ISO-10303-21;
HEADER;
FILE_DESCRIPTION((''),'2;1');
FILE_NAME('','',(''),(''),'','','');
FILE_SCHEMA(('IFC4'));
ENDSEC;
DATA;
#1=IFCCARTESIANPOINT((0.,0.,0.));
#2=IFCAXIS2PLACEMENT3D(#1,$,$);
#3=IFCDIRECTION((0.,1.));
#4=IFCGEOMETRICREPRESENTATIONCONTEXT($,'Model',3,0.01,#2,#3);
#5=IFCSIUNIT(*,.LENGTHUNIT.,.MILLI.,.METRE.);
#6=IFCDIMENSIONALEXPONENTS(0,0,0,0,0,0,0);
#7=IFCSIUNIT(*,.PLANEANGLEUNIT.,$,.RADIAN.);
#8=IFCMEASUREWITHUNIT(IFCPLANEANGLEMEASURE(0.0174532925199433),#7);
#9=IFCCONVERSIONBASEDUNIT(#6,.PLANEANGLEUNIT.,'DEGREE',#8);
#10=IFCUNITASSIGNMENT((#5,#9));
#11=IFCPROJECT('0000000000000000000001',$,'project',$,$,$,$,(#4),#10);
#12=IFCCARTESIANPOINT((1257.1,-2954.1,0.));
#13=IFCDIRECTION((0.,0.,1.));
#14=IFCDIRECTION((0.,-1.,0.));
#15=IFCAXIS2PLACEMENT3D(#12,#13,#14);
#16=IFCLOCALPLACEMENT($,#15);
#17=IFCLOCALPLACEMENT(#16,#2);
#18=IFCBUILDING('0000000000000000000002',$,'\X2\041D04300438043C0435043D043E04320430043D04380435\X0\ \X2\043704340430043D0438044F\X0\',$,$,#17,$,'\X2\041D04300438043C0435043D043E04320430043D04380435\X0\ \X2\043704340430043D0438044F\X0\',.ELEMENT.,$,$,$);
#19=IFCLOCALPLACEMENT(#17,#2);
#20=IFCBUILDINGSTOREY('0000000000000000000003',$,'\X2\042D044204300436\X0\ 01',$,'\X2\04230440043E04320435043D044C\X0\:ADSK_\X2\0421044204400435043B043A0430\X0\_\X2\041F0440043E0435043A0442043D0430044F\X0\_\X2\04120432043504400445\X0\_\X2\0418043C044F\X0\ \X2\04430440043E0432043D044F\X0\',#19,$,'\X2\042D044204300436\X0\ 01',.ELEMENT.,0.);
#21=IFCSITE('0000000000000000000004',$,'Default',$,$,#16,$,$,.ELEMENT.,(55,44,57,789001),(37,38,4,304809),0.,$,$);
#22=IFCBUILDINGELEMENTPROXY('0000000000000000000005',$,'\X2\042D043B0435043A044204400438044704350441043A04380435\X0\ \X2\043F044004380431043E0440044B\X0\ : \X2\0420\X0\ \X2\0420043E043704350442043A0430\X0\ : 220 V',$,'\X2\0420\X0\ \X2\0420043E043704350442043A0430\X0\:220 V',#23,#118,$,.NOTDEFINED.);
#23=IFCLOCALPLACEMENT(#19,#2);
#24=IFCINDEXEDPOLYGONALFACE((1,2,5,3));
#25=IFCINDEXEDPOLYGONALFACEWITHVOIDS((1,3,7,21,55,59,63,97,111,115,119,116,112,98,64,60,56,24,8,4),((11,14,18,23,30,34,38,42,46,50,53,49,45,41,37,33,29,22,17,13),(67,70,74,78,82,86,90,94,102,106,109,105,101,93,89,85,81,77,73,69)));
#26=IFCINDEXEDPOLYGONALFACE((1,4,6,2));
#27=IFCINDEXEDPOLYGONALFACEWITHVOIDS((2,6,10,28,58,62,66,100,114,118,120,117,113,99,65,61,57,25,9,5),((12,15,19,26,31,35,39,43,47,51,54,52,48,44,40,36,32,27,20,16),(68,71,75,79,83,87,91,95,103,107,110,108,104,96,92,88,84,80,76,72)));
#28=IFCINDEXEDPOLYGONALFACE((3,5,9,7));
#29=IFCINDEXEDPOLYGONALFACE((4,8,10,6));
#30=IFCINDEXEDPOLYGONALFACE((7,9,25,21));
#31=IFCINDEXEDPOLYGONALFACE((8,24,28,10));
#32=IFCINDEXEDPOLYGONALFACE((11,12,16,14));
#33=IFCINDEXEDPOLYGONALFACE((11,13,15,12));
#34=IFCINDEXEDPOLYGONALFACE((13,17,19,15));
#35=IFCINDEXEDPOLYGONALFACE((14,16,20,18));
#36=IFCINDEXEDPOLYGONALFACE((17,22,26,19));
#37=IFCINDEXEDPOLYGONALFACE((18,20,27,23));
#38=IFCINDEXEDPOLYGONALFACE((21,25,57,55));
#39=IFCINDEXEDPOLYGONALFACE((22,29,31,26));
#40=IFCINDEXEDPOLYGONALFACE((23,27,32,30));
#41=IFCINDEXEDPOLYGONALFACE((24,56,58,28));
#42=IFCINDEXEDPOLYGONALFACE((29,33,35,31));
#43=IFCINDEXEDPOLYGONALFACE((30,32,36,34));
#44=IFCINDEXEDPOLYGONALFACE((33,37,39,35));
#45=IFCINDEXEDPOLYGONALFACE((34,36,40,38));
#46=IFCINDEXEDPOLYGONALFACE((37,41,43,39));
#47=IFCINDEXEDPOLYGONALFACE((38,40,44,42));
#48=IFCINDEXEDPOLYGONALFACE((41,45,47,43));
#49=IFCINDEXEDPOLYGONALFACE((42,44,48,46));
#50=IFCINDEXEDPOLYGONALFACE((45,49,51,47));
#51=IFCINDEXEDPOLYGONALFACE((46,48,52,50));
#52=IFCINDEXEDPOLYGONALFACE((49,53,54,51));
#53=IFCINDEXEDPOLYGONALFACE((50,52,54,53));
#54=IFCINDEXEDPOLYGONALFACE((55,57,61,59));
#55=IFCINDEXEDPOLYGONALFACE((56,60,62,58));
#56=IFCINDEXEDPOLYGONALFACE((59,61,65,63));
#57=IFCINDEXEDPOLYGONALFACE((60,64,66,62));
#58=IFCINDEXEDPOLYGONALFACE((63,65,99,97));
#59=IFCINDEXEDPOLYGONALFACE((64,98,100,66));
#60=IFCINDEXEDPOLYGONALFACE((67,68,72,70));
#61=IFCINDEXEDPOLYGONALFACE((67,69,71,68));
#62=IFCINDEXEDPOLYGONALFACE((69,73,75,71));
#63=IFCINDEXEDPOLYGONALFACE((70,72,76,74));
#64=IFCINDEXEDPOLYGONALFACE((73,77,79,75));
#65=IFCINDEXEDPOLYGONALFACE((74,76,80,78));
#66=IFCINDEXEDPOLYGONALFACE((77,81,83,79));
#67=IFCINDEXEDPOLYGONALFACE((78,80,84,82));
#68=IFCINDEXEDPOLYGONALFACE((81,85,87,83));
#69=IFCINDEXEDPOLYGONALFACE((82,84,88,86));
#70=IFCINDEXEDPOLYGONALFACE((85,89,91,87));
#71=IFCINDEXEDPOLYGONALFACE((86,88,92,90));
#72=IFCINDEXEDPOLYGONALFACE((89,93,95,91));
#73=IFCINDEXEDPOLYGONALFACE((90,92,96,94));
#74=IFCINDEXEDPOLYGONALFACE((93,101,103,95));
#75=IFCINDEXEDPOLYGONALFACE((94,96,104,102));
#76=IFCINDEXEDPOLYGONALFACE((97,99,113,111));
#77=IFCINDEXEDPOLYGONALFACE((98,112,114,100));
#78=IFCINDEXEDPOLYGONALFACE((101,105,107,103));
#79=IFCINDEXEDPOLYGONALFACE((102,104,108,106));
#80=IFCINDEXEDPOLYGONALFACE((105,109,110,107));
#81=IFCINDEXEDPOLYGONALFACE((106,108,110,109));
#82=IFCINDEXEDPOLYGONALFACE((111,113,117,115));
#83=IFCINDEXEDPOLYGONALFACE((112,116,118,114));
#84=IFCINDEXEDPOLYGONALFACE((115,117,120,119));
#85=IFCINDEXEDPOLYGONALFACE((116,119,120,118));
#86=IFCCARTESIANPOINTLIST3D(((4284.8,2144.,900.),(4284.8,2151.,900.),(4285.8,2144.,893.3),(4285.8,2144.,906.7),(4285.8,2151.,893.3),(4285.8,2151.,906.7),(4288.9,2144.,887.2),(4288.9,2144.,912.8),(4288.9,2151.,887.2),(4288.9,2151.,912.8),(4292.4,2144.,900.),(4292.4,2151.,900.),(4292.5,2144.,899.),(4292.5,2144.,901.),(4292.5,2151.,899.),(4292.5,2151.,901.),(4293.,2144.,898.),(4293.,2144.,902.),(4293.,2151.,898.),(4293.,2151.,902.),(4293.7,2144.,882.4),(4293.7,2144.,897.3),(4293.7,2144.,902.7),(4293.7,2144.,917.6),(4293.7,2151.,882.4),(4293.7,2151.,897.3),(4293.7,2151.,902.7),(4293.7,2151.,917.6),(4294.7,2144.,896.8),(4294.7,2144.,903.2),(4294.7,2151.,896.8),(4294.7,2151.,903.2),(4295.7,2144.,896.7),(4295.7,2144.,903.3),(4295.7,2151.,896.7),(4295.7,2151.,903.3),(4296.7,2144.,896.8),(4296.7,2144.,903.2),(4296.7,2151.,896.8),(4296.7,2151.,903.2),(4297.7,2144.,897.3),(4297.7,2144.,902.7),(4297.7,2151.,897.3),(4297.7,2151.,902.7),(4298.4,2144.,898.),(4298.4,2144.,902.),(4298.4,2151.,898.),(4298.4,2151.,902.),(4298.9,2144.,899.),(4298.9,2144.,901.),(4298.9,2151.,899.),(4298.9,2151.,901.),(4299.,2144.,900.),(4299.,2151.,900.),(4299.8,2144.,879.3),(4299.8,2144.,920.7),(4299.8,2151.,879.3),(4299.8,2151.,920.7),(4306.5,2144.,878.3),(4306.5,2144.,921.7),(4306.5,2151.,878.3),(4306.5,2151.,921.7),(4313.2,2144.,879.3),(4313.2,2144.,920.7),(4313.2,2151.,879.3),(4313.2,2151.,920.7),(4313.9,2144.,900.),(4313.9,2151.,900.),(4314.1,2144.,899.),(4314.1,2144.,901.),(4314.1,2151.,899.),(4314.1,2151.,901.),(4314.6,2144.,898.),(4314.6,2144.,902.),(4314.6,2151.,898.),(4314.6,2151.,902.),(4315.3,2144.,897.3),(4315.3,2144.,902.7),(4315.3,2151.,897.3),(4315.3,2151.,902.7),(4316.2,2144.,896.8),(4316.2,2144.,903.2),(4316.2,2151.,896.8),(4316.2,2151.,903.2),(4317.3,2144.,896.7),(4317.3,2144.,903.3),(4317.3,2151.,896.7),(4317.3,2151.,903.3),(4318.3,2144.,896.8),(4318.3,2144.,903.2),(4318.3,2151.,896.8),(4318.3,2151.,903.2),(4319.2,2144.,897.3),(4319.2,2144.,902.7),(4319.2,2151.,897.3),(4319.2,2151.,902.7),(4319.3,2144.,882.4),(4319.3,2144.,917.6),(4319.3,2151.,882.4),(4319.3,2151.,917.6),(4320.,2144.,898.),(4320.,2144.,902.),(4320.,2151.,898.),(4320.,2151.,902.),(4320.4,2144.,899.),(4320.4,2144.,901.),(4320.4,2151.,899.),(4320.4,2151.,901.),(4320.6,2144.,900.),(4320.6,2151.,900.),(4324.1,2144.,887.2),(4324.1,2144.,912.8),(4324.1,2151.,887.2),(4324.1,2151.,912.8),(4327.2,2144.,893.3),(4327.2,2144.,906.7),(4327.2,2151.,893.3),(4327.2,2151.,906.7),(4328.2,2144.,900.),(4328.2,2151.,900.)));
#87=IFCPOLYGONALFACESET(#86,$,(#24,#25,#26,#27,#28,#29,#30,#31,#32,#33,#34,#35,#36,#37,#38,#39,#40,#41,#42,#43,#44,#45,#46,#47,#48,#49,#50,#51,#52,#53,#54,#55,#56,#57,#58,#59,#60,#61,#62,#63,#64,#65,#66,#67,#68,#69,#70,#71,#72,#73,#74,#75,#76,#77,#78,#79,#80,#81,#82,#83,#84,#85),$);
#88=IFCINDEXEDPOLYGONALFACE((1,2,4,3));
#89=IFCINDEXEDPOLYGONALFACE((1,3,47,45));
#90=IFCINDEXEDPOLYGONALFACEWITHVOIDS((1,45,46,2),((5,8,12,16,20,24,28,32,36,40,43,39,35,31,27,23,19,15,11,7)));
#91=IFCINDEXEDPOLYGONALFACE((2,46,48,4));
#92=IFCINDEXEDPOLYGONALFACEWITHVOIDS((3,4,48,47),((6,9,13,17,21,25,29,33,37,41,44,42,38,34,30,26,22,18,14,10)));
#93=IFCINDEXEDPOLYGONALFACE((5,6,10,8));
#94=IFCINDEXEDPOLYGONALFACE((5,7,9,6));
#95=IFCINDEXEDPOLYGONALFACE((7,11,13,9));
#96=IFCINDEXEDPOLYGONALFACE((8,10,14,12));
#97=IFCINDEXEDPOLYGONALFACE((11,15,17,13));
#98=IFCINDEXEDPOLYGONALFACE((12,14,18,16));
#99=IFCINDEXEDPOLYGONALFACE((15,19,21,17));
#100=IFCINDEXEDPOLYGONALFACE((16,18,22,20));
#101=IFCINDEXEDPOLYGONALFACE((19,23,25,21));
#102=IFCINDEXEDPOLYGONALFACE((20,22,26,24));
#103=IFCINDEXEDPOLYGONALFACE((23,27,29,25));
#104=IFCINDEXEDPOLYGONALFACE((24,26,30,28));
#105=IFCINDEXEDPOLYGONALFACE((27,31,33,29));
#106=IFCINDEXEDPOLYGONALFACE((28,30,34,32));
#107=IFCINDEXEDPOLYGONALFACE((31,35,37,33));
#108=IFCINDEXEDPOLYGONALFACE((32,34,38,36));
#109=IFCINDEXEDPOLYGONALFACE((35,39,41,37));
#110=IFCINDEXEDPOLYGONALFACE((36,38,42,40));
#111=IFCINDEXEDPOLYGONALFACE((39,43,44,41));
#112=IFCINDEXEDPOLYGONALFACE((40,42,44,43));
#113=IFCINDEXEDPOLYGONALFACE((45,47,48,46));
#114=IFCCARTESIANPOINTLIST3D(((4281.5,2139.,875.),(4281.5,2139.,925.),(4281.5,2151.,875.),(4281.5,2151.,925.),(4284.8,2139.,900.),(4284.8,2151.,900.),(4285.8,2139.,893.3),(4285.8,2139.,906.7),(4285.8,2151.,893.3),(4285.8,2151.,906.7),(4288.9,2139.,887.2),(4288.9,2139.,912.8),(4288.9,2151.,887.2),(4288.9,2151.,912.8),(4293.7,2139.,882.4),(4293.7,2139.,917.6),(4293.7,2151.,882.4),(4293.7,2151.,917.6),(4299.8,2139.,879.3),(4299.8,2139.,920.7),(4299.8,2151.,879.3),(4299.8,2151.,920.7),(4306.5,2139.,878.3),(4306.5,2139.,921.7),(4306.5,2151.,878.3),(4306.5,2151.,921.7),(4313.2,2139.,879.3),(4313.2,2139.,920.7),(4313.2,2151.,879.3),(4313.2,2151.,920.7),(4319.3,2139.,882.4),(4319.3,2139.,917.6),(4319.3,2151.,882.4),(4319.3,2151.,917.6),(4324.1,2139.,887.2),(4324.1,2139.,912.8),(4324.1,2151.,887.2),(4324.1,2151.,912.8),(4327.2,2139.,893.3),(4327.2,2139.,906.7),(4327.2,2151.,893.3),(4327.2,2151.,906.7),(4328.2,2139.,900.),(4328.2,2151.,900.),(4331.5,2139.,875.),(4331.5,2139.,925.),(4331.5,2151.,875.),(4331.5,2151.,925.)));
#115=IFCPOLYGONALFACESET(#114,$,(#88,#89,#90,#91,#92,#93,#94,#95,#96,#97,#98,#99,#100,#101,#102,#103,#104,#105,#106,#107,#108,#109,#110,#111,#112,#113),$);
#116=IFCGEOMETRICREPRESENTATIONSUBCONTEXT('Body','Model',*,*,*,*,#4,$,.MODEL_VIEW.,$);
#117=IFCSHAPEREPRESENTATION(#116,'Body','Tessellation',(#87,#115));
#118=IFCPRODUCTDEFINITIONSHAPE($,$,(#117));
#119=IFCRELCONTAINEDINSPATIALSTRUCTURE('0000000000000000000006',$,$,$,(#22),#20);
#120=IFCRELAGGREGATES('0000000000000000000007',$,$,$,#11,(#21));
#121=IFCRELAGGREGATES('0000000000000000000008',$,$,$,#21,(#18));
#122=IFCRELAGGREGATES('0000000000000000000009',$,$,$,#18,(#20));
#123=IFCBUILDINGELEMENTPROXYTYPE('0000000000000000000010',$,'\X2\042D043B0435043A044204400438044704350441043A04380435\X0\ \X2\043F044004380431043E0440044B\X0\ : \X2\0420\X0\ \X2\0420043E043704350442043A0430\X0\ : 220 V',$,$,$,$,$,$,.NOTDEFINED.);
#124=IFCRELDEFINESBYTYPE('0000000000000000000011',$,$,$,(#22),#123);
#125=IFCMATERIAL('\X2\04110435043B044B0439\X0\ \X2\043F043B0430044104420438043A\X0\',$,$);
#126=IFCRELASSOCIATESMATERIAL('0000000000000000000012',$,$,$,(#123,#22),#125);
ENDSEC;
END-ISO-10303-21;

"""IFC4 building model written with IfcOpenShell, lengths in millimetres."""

from ifc_helpers import new_model, entity, si_unit, converted_unit, direction, frame, origin, place, context, subcontext, project, spatial, indexed_curve, outline, extrude, source, transform, mapped, material, type_object, type_shapes, element, save


model = new_model("IFC4")

# Units and contexts
model_context = context("Model", 3, precision=0.01, world=origin(), true_north=direction((0.0, 1.0)))
body_context = subcontext(model_context, "Body", "Model", "MODEL_VIEW")
ifc_project = project(units=[si_unit("LENGTHUNIT", "METRE", prefix="MILLI"), converted_unit("PLANEANGLEUNIT", "DEGREE", entity("IfcPlaneAngleMeasure", 0.0174532925199433), si_unit("PLANEANGLEUNIT", "RADIAN"), dimensions=[0, 0, 0, 0, 0, 0, 0])], contexts=[model_context])

# Site, building, storey
site_placement = place(None, frame((1257.1, -2954.1, 0.0), z_axis=(0.0, 0.0, 1.0), x_axis=(0.0, -1.0, 0.0)))
site = spatial("IfcSite", under=ifc_project, at=site_placement, Name="Default", CompositionType="ELEMENT", RefLatitude=(55, 44, 57, 789001), RefLongitude=(37, 38, 4, 304809), RefElevation=0.0)
building_placement = place(site_placement, origin())
building = spatial("IfcBuilding", under=site, at=building_placement, Name="Наименование здания", LongName="Наименование здания", CompositionType="ELEMENT")
storey_placement = place(building_placement, origin())
storey = spatial("IfcBuildingStorey", under=building, at=storey_placement, Name="Этаж 01", ObjectType="Уровень:ADSK_Стрелка_Проектная_Вверх_Имя уровня", LongName="Этаж 01", CompositionType="ELEMENT", Elevation=0.0)

# Building element proxy
ifc_material_1 = material(Name="Белый пластик")
building_element_proxy_type_1 = type_object("IfcBuildingElementProxyType", Name="Электрические приборы : Р Розетка : 220 V", PredefinedType="NOTDEFINED", material=ifc_material_1)
shared_shape_1 = source(origin(), body_context, "Body", "SweptSolid", [
    extrude(outline(indexed_curve([(21.7, 0.0), (20.7, 6.7), (17.6, 12.8), (12.8, 17.6), (6.7, 20.7), (0.0, 21.7), (-6.7, 20.7), (-12.8, 17.6), (-17.6, 12.8), (-20.7, 6.7), (-21.7, 0.0), (-20.7, -6.7), (-17.6, -12.8), (-12.8, -17.6), (-6.7, -20.7), (0.0, -21.7), (6.7, -20.7), (12.8, -17.6), (17.6, -12.8), (20.7, -6.7), (21.7, 0.0)], self_intersect=False), holes=[indexed_curve([(-7.5, 0.0), (-7.6, -1.0), (-8.1, -2.0), (-8.8, -2.7), (-9.8, -3.2), (-10.8, -3.3), (-11.8, -3.2), (-12.8, -2.7), (-13.5, -2.0), (-14.0, -1.0), (-14.1, 0.0), (-14.0, 1.0), (-13.5, 2.0), (-12.8, 2.7), (-11.8, 3.2), (-10.8, 3.3), (-9.8, 3.2), (-8.8, 2.7), (-8.1, 2.0), (-7.6, 1.0), (-7.5, 0.0)], self_intersect=False), indexed_curve([(14.1, 0.0), (13.9, -1.0), (13.5, -2.0), (12.7, -2.7), (11.8, -3.2), (10.8, -3.3), (9.7, -3.2), (8.8, -2.7), (8.1, -2.0), (7.6, -1.0), (7.4, 0.0), (7.6, 1.0), (8.1, 2.0), (8.8, 2.7), (9.7, 3.2), (10.8, 3.3), (11.8, 3.2), (12.7, 2.7), (13.5, 2.0), (13.9, 1.0), (14.1, 0.0)], self_intersect=False)]), frame((345.3, -712.5, 0.0)), (0.0, 0.0, 1.0), 7.0),
    extrude(outline(indexed_curve([(-25.0, -25.0), (25.0, -25.0), (25.0, 25.0), (-25.0, 25.0), (-25.0, -25.0)], self_intersect=False), holes=[indexed_curve([(-21.7, 0.0), (-20.7, 6.7), (-17.6, 12.8), (-12.8, 17.6), (-6.7, 20.7), (0.0, 21.7), (6.7, 20.7), (12.8, 17.6), (17.6, 12.8), (20.7, 6.7), (21.7, 0.0), (20.7, -6.7), (17.6, -12.8), (12.8, -17.6), (6.7, -20.7), (0.0, -21.7), (-6.7, -20.7), (-12.8, -17.6), (-17.6, -12.8), (-20.7, -6.7), (-21.7, 0.0)], self_intersect=False)]), frame((345.3, -712.5, 0.0), z_axis=(0.0, 0.0, 1.0), x_axis=(-1.0, 0.0, 0.0)), (0.0, 0.0, 1.0), 12.0),
])
type_shapes(building_element_proxy_type_1, [shared_shape_1])
for number, where, z_axis, x_axis, name in (
    (1, (3961.2, 2151.0, 1612.5), (0.0, -1.0, 0.0), (1.0, 0.0, 0.0), "Электрические приборы : Р Розетка : 220 V"),
):
    element("IfcBuildingElementProxy", number, at=place(storey_placement, frame(where, z_axis=z_axis, x_axis=x_axis)), inside=storey, type_object=building_element_proxy_type_1, material=ifc_material_1, Name=name, ObjectType="Р Розетка:220 V", PredefinedType="NOTDEFINED", context=body_context, shape_type="MappedRepresentation", body=[
        mapped(shared_shape_1, transform((0.0, 0.0, 0.0), scale=1.0)),
    ])

save(model, "model.ifc")
